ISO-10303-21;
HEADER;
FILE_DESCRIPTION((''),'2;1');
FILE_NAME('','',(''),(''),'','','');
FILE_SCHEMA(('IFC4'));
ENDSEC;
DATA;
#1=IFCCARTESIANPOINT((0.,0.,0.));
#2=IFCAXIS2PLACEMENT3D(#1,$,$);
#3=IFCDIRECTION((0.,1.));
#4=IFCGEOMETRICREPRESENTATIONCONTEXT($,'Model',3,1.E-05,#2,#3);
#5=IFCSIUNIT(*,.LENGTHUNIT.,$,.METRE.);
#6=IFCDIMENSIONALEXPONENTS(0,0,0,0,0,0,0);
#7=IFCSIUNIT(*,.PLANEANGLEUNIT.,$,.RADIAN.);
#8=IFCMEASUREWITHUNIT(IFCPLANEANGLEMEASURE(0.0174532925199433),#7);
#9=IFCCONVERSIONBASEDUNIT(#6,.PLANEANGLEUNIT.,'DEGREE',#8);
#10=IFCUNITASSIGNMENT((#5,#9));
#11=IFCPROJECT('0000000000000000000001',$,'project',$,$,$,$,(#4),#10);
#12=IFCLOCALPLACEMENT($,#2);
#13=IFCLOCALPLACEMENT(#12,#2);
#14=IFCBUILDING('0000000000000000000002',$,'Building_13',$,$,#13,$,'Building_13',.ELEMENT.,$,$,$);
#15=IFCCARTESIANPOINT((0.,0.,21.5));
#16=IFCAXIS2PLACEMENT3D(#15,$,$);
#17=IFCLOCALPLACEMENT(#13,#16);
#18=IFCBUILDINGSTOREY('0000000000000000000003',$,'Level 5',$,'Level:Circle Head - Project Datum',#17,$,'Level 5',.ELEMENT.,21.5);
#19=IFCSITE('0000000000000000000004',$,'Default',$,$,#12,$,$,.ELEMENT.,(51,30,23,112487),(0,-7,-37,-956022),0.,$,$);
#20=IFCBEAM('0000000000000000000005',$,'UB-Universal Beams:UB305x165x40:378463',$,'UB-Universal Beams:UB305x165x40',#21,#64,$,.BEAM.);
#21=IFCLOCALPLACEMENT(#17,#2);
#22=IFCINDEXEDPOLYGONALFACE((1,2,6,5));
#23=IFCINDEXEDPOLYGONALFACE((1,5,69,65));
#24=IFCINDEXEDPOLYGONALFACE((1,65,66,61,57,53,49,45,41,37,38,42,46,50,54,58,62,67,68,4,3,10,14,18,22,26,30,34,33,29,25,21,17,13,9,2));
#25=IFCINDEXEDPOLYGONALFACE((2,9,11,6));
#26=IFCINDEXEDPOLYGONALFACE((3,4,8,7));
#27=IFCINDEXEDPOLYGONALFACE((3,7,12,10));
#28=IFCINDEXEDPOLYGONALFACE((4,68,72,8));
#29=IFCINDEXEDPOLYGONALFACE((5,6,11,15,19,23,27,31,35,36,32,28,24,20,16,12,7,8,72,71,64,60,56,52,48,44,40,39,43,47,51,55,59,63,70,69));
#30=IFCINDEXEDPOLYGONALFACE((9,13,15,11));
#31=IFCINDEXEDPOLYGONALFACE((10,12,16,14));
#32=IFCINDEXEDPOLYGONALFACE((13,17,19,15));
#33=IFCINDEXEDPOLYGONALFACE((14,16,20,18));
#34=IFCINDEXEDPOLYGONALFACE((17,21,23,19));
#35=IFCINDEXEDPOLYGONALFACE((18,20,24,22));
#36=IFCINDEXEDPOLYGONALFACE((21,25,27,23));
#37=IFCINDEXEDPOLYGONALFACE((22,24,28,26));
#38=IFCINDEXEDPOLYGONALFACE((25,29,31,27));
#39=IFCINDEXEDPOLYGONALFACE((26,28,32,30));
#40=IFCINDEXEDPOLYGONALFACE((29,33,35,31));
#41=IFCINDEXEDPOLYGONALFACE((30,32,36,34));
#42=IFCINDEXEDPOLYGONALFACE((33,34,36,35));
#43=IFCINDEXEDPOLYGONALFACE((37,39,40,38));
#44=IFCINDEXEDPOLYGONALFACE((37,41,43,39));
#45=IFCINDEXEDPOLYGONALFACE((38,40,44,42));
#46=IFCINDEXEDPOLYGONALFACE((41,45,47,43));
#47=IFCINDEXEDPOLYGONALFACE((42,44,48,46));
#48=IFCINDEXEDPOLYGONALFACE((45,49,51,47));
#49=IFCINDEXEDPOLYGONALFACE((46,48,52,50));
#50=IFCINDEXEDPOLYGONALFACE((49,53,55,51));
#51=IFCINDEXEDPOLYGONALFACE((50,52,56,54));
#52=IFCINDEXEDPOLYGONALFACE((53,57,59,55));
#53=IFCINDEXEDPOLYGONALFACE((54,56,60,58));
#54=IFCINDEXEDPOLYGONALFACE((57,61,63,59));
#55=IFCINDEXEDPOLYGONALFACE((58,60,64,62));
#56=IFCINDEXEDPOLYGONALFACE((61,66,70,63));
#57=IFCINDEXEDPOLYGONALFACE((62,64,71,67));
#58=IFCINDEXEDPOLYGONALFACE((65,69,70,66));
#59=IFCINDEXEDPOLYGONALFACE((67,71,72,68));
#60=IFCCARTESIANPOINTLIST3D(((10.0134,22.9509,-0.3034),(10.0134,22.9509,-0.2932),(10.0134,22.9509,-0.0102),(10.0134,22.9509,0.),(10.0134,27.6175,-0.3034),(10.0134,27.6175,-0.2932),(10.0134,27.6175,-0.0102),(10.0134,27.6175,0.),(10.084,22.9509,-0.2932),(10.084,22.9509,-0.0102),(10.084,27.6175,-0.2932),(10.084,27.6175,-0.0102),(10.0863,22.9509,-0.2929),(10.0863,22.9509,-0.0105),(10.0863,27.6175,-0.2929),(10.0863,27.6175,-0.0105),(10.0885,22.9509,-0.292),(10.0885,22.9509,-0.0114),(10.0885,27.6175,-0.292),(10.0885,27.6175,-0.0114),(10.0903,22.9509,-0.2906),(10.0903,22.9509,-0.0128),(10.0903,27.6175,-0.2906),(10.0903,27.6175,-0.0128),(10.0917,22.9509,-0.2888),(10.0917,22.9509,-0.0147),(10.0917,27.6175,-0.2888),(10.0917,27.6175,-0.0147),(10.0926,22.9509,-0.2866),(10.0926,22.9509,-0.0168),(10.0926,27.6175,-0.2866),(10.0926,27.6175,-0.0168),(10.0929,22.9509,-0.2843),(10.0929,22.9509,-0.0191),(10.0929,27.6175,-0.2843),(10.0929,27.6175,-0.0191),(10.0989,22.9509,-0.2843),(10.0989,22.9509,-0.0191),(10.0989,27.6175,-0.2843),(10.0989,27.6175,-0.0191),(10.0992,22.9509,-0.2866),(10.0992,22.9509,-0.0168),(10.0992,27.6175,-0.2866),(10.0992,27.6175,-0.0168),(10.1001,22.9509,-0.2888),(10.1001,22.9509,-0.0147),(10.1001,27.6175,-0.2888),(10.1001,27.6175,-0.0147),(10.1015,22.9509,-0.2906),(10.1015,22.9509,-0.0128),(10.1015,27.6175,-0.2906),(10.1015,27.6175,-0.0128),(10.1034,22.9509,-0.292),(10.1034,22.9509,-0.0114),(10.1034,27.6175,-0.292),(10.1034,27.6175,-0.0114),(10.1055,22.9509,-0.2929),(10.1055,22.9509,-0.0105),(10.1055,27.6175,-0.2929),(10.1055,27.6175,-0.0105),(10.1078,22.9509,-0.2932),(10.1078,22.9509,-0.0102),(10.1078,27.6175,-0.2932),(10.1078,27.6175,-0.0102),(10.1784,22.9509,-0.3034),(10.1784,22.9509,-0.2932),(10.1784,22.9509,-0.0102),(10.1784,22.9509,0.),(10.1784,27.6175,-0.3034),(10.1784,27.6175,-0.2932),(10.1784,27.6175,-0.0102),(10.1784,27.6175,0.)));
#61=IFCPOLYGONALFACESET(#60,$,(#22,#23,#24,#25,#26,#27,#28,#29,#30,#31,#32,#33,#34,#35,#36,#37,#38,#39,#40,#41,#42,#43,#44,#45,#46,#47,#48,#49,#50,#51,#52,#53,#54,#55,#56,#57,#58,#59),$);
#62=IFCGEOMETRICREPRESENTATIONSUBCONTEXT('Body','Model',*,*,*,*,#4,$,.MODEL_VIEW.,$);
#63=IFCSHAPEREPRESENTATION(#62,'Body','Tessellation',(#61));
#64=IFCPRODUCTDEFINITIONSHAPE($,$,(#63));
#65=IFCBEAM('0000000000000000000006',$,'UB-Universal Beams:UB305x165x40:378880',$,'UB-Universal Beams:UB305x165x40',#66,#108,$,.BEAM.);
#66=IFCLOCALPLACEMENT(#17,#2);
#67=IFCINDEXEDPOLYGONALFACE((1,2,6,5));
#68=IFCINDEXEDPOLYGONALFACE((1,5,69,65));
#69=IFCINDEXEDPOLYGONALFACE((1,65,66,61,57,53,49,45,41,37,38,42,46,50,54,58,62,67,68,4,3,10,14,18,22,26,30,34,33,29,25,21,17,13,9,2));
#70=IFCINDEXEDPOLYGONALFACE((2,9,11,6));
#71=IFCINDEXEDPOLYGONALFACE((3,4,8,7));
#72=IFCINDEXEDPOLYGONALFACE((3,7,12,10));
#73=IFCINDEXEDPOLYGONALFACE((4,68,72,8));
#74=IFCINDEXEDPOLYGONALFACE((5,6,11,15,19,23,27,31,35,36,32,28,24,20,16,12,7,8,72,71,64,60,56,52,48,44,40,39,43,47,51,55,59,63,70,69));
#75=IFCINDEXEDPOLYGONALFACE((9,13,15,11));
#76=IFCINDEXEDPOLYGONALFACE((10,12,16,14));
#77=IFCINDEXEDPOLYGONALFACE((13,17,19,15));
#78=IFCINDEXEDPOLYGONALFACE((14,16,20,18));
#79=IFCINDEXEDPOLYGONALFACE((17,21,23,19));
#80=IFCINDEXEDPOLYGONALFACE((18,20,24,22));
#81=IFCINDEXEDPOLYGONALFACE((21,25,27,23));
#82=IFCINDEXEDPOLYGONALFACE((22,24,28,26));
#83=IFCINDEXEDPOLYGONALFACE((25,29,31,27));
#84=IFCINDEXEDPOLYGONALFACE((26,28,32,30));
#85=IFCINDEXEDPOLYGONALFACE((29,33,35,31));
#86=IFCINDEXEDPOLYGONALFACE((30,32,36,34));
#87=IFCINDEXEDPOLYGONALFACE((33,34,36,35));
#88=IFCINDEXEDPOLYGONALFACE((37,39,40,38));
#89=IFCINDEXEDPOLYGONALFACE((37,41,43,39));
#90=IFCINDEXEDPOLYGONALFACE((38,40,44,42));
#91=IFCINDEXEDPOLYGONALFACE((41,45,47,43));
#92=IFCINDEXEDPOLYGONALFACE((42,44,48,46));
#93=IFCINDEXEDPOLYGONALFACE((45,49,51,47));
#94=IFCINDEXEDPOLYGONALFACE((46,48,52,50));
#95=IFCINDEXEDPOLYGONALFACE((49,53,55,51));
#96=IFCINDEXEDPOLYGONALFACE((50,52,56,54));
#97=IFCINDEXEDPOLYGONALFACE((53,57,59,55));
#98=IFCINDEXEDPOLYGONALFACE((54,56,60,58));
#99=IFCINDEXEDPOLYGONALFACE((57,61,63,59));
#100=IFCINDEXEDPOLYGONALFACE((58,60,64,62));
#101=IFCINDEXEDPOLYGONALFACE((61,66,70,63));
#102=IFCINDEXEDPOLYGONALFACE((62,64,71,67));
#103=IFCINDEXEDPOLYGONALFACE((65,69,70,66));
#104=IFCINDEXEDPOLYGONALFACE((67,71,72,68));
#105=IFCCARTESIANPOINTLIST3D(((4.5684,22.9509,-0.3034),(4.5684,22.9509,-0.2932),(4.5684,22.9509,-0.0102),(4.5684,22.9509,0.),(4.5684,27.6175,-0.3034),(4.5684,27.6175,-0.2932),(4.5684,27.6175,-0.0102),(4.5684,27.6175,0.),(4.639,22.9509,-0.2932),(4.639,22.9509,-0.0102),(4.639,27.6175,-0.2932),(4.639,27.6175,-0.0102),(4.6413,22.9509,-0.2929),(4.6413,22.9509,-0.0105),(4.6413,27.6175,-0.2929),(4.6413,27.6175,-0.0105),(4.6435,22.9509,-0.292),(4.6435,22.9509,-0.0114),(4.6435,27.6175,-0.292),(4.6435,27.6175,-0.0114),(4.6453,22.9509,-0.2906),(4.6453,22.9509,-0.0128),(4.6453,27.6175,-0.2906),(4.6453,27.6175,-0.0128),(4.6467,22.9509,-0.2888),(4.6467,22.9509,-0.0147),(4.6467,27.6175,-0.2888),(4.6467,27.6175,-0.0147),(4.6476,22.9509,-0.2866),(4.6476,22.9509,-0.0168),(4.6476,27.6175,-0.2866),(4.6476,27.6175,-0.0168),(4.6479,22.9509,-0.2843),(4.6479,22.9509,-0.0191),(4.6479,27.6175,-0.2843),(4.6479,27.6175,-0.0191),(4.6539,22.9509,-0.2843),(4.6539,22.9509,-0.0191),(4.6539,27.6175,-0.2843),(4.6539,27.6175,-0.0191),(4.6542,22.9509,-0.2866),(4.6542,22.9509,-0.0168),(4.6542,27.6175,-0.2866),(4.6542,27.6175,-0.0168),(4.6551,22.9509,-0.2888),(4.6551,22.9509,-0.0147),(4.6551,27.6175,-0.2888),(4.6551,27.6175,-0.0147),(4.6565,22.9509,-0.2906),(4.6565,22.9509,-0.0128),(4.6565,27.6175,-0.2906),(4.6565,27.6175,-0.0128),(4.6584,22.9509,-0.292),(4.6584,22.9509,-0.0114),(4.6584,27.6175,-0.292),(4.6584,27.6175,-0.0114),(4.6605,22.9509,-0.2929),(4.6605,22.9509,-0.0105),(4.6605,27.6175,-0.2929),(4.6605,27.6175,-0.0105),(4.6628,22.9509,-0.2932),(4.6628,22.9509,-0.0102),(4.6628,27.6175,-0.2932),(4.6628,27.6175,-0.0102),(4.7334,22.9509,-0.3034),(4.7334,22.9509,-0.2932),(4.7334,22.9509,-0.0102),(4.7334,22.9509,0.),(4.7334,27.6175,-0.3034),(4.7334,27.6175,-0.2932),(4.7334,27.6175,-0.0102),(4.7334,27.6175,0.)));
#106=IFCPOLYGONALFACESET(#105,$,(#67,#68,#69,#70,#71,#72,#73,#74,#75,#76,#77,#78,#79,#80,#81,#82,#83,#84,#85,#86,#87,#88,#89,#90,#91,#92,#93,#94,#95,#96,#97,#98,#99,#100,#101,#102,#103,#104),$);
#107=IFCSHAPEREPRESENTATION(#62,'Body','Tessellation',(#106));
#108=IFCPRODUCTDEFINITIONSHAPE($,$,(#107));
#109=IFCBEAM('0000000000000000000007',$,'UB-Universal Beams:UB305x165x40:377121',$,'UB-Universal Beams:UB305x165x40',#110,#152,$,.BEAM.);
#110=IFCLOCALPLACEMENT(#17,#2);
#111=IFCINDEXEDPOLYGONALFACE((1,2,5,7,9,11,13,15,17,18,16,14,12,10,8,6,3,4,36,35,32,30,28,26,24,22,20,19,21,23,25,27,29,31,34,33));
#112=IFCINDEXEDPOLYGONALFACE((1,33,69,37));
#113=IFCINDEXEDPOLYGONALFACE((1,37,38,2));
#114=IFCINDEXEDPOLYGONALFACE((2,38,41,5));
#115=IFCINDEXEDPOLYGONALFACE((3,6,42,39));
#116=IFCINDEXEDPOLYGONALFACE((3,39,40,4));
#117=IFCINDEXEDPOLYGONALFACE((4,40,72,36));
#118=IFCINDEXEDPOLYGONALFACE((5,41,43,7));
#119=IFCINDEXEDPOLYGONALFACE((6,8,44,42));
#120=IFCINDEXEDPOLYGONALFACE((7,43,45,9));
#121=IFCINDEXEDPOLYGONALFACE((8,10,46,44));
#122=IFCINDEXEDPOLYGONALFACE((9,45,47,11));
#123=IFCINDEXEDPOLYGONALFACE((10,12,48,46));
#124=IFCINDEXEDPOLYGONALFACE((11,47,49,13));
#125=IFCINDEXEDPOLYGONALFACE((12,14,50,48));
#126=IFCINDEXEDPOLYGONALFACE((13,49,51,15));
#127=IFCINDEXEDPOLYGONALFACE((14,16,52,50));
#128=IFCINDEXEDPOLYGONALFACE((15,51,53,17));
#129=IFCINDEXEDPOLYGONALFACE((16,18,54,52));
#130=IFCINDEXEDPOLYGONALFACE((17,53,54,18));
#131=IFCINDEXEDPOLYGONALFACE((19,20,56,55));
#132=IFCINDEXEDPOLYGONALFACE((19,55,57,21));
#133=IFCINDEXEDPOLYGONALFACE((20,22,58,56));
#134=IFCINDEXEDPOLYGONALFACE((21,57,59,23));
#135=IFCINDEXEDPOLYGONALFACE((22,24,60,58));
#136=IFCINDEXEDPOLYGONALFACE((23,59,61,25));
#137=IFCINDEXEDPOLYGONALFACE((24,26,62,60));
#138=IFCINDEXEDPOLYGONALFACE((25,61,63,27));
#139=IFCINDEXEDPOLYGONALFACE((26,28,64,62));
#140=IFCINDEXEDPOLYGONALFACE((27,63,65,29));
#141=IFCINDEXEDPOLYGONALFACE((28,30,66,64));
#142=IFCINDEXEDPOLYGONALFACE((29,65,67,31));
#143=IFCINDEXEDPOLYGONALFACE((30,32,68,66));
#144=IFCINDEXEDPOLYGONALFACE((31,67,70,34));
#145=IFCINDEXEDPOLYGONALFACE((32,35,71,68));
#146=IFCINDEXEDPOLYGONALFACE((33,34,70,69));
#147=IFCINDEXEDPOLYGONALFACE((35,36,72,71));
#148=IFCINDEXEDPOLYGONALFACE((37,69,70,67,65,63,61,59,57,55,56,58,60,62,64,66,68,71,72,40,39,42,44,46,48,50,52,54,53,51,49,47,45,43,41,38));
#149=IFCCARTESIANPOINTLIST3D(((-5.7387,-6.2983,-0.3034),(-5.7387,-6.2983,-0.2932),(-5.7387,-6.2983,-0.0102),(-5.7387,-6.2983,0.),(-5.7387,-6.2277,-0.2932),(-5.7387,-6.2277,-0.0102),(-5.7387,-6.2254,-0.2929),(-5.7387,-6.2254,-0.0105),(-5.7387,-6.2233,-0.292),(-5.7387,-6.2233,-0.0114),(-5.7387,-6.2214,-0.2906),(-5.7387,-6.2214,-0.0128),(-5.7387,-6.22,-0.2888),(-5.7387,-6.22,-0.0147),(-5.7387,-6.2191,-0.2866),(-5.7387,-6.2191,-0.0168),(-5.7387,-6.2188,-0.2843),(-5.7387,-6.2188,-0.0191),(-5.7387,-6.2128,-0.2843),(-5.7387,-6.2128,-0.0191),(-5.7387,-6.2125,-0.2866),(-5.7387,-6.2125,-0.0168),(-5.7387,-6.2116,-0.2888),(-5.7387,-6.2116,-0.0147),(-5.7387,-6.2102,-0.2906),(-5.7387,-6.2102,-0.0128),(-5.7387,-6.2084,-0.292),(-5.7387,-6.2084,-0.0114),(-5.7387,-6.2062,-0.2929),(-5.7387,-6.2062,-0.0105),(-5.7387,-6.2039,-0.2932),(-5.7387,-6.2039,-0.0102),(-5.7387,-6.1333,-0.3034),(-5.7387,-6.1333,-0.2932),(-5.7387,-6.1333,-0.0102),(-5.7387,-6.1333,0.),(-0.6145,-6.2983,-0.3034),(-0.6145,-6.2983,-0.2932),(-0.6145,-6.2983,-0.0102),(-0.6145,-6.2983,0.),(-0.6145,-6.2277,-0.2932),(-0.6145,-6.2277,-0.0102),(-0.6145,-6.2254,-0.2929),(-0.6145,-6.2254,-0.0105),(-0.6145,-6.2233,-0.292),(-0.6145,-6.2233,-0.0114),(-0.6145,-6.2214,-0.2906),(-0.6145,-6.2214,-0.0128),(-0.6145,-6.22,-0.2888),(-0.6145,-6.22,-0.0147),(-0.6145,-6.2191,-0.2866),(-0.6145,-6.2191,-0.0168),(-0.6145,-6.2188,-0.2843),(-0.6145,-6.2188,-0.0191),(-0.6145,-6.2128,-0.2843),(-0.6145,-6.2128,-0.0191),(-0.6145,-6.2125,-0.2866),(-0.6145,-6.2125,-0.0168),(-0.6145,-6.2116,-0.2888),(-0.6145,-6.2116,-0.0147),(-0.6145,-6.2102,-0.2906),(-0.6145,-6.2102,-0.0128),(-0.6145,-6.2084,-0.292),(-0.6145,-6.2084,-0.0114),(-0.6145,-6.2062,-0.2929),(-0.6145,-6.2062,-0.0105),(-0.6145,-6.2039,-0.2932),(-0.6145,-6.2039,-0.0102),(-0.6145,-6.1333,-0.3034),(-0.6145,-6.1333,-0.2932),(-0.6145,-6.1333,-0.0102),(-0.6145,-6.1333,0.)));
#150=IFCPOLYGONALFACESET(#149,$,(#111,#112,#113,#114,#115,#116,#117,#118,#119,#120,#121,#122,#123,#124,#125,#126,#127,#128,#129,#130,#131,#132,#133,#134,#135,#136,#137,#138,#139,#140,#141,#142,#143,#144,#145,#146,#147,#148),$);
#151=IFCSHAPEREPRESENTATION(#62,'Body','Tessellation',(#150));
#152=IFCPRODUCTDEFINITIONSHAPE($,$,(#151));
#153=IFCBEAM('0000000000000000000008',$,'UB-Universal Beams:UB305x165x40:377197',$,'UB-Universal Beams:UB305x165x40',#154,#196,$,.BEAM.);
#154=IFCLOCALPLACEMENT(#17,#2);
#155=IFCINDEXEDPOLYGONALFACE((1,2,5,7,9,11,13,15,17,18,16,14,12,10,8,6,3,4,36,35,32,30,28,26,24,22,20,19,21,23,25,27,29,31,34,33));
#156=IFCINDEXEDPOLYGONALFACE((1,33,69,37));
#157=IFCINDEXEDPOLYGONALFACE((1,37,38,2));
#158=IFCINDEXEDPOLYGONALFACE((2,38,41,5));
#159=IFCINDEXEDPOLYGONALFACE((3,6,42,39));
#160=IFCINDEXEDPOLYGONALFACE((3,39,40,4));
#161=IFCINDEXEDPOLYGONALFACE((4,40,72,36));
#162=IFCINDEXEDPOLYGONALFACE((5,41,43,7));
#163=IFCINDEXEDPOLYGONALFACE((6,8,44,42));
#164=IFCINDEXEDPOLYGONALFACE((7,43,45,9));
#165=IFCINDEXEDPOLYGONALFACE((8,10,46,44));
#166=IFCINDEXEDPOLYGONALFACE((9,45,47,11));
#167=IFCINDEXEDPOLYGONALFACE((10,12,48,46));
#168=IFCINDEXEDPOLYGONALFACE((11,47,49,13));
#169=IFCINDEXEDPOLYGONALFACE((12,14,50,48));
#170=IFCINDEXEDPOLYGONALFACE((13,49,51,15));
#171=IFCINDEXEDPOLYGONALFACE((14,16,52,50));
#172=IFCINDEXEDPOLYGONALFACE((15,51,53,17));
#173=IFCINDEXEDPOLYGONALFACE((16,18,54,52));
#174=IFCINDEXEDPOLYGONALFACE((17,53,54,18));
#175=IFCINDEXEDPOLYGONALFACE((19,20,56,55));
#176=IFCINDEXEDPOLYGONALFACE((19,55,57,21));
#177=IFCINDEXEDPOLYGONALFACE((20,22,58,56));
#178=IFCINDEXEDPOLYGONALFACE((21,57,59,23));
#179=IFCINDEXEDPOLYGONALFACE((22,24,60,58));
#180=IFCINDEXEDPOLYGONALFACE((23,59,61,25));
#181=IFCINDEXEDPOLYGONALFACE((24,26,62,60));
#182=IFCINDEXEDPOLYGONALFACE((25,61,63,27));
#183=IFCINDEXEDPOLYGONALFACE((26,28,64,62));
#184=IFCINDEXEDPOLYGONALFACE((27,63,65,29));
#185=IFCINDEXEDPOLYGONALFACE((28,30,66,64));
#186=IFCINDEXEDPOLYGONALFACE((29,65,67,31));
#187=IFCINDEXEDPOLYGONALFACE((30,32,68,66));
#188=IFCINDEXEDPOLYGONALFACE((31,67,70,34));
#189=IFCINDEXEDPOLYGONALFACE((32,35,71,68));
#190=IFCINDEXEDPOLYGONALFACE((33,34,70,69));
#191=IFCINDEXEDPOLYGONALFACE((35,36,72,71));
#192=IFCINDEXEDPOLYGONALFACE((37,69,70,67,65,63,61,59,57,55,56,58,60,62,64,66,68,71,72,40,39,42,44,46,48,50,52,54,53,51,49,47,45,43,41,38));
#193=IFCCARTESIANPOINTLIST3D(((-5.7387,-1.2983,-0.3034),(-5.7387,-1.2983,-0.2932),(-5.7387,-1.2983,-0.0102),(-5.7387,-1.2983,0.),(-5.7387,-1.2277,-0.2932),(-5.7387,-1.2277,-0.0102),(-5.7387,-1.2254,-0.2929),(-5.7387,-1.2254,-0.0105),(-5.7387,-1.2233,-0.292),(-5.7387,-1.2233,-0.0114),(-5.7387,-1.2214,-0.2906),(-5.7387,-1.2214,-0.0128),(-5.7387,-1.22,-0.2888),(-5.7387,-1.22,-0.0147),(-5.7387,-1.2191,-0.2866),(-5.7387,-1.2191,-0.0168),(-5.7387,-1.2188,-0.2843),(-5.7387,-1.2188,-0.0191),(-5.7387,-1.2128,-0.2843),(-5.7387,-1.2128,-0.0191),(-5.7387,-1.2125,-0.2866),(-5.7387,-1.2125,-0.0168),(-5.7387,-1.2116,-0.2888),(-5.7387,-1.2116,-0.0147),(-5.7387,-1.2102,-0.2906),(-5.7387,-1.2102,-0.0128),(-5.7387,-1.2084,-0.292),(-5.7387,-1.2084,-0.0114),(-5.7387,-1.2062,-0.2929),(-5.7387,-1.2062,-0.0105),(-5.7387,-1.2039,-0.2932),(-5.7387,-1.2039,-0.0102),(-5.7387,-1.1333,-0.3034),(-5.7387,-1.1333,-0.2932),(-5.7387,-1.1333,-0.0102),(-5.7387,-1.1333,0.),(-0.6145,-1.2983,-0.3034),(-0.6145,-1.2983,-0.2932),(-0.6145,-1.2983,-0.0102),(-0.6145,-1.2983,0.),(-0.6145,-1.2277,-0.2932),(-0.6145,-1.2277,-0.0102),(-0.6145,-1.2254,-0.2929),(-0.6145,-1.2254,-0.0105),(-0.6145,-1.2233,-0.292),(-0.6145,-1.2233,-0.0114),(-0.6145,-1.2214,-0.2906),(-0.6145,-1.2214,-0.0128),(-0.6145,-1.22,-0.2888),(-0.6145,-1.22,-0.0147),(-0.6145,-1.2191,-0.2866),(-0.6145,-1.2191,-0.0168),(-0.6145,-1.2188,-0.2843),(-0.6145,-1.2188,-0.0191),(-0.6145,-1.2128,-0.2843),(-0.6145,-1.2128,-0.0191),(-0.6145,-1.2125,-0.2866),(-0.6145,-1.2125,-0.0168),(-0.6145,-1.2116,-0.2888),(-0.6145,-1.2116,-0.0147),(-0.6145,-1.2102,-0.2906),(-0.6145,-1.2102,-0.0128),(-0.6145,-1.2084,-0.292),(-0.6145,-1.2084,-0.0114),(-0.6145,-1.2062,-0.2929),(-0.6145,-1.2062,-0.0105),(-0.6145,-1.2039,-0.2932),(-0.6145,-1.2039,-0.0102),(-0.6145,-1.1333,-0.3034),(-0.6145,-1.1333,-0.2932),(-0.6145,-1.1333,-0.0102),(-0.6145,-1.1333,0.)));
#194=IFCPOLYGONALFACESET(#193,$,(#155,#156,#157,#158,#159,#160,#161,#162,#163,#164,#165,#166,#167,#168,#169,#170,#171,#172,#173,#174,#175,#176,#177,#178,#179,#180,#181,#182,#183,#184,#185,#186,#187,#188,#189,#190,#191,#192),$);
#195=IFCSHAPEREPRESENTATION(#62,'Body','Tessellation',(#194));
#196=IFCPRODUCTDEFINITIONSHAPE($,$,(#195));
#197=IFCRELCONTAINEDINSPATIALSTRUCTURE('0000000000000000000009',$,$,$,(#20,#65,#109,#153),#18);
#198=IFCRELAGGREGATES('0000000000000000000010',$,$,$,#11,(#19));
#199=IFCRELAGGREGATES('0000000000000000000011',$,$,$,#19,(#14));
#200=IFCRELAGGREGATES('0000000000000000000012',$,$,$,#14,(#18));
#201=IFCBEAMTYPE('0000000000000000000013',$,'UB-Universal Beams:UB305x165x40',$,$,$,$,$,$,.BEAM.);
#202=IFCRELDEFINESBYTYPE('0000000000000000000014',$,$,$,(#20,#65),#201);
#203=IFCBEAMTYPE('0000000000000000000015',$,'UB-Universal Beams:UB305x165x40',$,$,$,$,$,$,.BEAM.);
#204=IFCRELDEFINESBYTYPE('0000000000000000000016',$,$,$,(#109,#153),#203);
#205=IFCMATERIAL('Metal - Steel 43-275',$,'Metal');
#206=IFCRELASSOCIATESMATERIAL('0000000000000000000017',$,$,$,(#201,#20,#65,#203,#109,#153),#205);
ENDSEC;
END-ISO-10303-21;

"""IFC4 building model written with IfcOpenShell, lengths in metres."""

from ifc_helpers import new_model, entity, si_unit, converted_unit, direction, frame, origin, place, context, subcontext, project, spatial, line, arc, indexed_curve, outline, extrude, source, transform, mapped, material, type_object, type_shapes, element, save


model = new_model("IFC4")

# Units and contexts
model_context = context("Model", 3, precision=1e-05, world=origin(), true_north=direction((0.0, 1.0)))
body_context = subcontext(model_context, "Body", "Model", "MODEL_VIEW")
ifc_project = project(units=[si_unit("LENGTHUNIT", "METRE"), converted_unit("PLANEANGLEUNIT", "DEGREE", entity("IfcPlaneAngleMeasure", 0.0174532925199433), si_unit("PLANEANGLEUNIT", "RADIAN"), dimensions=[0, 0, 0, 0, 0, 0, 0])], contexts=[model_context])

# Site, building, storey
site_placement = place(None, origin())
site = spatial("IfcSite", under=ifc_project, at=site_placement, Name="Default", CompositionType="ELEMENT", RefLatitude=(51, 30, 23, 112487), RefLongitude=(0, -7, -37, -956022), RefElevation=0.0)
building_placement = place(site_placement, origin())
building = spatial("IfcBuilding", under=site, at=building_placement, Name="Building_13", LongName="Building_13", CompositionType="ELEMENT")
storey_placement = place(building_placement, frame((0.0, 0.0, 21.5)))
storey = spatial("IfcBuildingStorey", under=building, at=storey_placement, Name="Level 5", ObjectType="Level:Circle Head - Project Datum", LongName="Level 5", CompositionType="ELEMENT", Elevation=21.5)

# Beams
ifc_material = material(Name="Metal - Steel 43-275", Category="Metal")
beam_type_1 = type_object("IfcBeamType", Name="UB-Universal Beams:UB305x165x40", PredefinedType="BEAM", material=ifc_material)
shared_shape_1 = source(origin(), body_context, "Body", "SweptSolid", [
    extrude(outline(indexed_curve([(-0.0825, -0.1415), (-0.0825, -0.1517), (0.0825, -0.1517), (0.0825, -0.1415), (0.0119, -0.1415), (0.0056, -0.1389), (0.003, -0.1326), (0.003, 0.1326), (0.0056, 0.1389), (0.0119, 0.1415), (0.0825, 0.1415), (0.0825, 0.1517), (-0.0825, 0.1517), (-0.0825, 0.1415), (-0.0119, 0.1415), (-0.0056, 0.1389), (-0.003, 0.1326), (-0.003, -0.1326), (-0.0056, -0.1389), (-0.0119, -0.1415)], segments=[line(1, 2, 3, 4, 5), arc(5, 6, 7), line(7, 8), arc(8, 9, 10), line(10, 11, 12, 13, 14, 15), arc(15, 16, 17), line(17, 18), arc(18, 19, 20), line(20, 1)], self_intersect=False)), frame((-2.3333, 0.0, 0.0), z_axis=(-1.0, 0.0, 0.0), x_axis=(0.0, -1.0, 0.0)), (0.0, 0.0, -1.0), 4.6666),
])
type_shapes(beam_type_1, [shared_shape_1])
for number, where, z_axis, x_axis, name in (
    (1, (10.0959, 25.2842, -0.1517), (0.0, 0.0, 1.0), (0.0, -1.0, 0.0), "UB-Universal Beams:UB305x165x40:378463"),
    (2, (4.6509, 25.2842, -0.1517), (0.0, 0.0, 1.0), (0.0, -1.0, 0.0), "UB-Universal Beams:UB305x165x40:378880"),
):
    element("IfcBeam", number, at=place(storey_placement, frame(where, z_axis=z_axis, x_axis=x_axis)), inside=storey, type_object=beam_type_1, material=ifc_material, Name=name, ObjectType="UB-Universal Beams:UB305x165x40", PredefinedType="BEAM", context=body_context, shape_type="MappedRepresentation", body=[
        mapped(shared_shape_1, transform((0.0, 0.0, 0.0), scale=1.0)),
    ])
beam_type_2 = type_object("IfcBeamType", Name="UB-Universal Beams:UB305x165x40", PredefinedType="BEAM", material=ifc_material)
shared_shape_2 = source(origin(), body_context, "Body", "SweptSolid", [
    extrude(outline(indexed_curve([(-0.0825, -0.1415), (-0.0825, -0.1517), (0.0825, -0.1517), (0.0825, -0.1415), (0.0119, -0.1415), (0.0056, -0.1389), (0.003, -0.1326), (0.003, 0.1326), (0.0056, 0.1389), (0.0119, 0.1415), (0.0825, 0.1415), (0.0825, 0.1517), (-0.0825, 0.1517), (-0.0825, 0.1415), (-0.0119, 0.1415), (-0.0056, 0.1389), (-0.003, 0.1326), (-0.003, -0.1326), (-0.0056, -0.1389), (-0.0119, -0.1415)], segments=[line(1, 2, 3, 4, 5), arc(5, 6, 7), line(7, 8), arc(8, 9, 10), line(10, 11, 12, 13, 14, 15), arc(15, 16, 17), line(17, 18), arc(18, 19, 20), line(20, 1)], self_intersect=False)), frame((-2.5621, 0.0, 0.0), z_axis=(-1.0, 0.0, 0.0), x_axis=(0.0, -1.0, 0.0)), (0.0, 0.0, -1.0), 5.1242),
])
type_shapes(beam_type_2, [shared_shape_2])
for number, where, name in (
    (3, (-3.1766, -6.2158, -0.1517), "UB-Universal Beams:UB305x165x40:377121"),
    (4, (-3.1766, -1.2158, -0.1517), "UB-Universal Beams:UB305x165x40:377197"),
):
    element("IfcBeam", number, at=place(storey_placement, frame(where)), inside=storey, type_object=beam_type_2, material=ifc_material, Name=name, ObjectType="UB-Universal Beams:UB305x165x40", PredefinedType="BEAM", context=body_context, shape_type="MappedRepresentation", body=[
        mapped(shared_shape_2, transform((0.0, 0.0, 0.0), scale=1.0)),
    ])

save(model, "model.ifc")
